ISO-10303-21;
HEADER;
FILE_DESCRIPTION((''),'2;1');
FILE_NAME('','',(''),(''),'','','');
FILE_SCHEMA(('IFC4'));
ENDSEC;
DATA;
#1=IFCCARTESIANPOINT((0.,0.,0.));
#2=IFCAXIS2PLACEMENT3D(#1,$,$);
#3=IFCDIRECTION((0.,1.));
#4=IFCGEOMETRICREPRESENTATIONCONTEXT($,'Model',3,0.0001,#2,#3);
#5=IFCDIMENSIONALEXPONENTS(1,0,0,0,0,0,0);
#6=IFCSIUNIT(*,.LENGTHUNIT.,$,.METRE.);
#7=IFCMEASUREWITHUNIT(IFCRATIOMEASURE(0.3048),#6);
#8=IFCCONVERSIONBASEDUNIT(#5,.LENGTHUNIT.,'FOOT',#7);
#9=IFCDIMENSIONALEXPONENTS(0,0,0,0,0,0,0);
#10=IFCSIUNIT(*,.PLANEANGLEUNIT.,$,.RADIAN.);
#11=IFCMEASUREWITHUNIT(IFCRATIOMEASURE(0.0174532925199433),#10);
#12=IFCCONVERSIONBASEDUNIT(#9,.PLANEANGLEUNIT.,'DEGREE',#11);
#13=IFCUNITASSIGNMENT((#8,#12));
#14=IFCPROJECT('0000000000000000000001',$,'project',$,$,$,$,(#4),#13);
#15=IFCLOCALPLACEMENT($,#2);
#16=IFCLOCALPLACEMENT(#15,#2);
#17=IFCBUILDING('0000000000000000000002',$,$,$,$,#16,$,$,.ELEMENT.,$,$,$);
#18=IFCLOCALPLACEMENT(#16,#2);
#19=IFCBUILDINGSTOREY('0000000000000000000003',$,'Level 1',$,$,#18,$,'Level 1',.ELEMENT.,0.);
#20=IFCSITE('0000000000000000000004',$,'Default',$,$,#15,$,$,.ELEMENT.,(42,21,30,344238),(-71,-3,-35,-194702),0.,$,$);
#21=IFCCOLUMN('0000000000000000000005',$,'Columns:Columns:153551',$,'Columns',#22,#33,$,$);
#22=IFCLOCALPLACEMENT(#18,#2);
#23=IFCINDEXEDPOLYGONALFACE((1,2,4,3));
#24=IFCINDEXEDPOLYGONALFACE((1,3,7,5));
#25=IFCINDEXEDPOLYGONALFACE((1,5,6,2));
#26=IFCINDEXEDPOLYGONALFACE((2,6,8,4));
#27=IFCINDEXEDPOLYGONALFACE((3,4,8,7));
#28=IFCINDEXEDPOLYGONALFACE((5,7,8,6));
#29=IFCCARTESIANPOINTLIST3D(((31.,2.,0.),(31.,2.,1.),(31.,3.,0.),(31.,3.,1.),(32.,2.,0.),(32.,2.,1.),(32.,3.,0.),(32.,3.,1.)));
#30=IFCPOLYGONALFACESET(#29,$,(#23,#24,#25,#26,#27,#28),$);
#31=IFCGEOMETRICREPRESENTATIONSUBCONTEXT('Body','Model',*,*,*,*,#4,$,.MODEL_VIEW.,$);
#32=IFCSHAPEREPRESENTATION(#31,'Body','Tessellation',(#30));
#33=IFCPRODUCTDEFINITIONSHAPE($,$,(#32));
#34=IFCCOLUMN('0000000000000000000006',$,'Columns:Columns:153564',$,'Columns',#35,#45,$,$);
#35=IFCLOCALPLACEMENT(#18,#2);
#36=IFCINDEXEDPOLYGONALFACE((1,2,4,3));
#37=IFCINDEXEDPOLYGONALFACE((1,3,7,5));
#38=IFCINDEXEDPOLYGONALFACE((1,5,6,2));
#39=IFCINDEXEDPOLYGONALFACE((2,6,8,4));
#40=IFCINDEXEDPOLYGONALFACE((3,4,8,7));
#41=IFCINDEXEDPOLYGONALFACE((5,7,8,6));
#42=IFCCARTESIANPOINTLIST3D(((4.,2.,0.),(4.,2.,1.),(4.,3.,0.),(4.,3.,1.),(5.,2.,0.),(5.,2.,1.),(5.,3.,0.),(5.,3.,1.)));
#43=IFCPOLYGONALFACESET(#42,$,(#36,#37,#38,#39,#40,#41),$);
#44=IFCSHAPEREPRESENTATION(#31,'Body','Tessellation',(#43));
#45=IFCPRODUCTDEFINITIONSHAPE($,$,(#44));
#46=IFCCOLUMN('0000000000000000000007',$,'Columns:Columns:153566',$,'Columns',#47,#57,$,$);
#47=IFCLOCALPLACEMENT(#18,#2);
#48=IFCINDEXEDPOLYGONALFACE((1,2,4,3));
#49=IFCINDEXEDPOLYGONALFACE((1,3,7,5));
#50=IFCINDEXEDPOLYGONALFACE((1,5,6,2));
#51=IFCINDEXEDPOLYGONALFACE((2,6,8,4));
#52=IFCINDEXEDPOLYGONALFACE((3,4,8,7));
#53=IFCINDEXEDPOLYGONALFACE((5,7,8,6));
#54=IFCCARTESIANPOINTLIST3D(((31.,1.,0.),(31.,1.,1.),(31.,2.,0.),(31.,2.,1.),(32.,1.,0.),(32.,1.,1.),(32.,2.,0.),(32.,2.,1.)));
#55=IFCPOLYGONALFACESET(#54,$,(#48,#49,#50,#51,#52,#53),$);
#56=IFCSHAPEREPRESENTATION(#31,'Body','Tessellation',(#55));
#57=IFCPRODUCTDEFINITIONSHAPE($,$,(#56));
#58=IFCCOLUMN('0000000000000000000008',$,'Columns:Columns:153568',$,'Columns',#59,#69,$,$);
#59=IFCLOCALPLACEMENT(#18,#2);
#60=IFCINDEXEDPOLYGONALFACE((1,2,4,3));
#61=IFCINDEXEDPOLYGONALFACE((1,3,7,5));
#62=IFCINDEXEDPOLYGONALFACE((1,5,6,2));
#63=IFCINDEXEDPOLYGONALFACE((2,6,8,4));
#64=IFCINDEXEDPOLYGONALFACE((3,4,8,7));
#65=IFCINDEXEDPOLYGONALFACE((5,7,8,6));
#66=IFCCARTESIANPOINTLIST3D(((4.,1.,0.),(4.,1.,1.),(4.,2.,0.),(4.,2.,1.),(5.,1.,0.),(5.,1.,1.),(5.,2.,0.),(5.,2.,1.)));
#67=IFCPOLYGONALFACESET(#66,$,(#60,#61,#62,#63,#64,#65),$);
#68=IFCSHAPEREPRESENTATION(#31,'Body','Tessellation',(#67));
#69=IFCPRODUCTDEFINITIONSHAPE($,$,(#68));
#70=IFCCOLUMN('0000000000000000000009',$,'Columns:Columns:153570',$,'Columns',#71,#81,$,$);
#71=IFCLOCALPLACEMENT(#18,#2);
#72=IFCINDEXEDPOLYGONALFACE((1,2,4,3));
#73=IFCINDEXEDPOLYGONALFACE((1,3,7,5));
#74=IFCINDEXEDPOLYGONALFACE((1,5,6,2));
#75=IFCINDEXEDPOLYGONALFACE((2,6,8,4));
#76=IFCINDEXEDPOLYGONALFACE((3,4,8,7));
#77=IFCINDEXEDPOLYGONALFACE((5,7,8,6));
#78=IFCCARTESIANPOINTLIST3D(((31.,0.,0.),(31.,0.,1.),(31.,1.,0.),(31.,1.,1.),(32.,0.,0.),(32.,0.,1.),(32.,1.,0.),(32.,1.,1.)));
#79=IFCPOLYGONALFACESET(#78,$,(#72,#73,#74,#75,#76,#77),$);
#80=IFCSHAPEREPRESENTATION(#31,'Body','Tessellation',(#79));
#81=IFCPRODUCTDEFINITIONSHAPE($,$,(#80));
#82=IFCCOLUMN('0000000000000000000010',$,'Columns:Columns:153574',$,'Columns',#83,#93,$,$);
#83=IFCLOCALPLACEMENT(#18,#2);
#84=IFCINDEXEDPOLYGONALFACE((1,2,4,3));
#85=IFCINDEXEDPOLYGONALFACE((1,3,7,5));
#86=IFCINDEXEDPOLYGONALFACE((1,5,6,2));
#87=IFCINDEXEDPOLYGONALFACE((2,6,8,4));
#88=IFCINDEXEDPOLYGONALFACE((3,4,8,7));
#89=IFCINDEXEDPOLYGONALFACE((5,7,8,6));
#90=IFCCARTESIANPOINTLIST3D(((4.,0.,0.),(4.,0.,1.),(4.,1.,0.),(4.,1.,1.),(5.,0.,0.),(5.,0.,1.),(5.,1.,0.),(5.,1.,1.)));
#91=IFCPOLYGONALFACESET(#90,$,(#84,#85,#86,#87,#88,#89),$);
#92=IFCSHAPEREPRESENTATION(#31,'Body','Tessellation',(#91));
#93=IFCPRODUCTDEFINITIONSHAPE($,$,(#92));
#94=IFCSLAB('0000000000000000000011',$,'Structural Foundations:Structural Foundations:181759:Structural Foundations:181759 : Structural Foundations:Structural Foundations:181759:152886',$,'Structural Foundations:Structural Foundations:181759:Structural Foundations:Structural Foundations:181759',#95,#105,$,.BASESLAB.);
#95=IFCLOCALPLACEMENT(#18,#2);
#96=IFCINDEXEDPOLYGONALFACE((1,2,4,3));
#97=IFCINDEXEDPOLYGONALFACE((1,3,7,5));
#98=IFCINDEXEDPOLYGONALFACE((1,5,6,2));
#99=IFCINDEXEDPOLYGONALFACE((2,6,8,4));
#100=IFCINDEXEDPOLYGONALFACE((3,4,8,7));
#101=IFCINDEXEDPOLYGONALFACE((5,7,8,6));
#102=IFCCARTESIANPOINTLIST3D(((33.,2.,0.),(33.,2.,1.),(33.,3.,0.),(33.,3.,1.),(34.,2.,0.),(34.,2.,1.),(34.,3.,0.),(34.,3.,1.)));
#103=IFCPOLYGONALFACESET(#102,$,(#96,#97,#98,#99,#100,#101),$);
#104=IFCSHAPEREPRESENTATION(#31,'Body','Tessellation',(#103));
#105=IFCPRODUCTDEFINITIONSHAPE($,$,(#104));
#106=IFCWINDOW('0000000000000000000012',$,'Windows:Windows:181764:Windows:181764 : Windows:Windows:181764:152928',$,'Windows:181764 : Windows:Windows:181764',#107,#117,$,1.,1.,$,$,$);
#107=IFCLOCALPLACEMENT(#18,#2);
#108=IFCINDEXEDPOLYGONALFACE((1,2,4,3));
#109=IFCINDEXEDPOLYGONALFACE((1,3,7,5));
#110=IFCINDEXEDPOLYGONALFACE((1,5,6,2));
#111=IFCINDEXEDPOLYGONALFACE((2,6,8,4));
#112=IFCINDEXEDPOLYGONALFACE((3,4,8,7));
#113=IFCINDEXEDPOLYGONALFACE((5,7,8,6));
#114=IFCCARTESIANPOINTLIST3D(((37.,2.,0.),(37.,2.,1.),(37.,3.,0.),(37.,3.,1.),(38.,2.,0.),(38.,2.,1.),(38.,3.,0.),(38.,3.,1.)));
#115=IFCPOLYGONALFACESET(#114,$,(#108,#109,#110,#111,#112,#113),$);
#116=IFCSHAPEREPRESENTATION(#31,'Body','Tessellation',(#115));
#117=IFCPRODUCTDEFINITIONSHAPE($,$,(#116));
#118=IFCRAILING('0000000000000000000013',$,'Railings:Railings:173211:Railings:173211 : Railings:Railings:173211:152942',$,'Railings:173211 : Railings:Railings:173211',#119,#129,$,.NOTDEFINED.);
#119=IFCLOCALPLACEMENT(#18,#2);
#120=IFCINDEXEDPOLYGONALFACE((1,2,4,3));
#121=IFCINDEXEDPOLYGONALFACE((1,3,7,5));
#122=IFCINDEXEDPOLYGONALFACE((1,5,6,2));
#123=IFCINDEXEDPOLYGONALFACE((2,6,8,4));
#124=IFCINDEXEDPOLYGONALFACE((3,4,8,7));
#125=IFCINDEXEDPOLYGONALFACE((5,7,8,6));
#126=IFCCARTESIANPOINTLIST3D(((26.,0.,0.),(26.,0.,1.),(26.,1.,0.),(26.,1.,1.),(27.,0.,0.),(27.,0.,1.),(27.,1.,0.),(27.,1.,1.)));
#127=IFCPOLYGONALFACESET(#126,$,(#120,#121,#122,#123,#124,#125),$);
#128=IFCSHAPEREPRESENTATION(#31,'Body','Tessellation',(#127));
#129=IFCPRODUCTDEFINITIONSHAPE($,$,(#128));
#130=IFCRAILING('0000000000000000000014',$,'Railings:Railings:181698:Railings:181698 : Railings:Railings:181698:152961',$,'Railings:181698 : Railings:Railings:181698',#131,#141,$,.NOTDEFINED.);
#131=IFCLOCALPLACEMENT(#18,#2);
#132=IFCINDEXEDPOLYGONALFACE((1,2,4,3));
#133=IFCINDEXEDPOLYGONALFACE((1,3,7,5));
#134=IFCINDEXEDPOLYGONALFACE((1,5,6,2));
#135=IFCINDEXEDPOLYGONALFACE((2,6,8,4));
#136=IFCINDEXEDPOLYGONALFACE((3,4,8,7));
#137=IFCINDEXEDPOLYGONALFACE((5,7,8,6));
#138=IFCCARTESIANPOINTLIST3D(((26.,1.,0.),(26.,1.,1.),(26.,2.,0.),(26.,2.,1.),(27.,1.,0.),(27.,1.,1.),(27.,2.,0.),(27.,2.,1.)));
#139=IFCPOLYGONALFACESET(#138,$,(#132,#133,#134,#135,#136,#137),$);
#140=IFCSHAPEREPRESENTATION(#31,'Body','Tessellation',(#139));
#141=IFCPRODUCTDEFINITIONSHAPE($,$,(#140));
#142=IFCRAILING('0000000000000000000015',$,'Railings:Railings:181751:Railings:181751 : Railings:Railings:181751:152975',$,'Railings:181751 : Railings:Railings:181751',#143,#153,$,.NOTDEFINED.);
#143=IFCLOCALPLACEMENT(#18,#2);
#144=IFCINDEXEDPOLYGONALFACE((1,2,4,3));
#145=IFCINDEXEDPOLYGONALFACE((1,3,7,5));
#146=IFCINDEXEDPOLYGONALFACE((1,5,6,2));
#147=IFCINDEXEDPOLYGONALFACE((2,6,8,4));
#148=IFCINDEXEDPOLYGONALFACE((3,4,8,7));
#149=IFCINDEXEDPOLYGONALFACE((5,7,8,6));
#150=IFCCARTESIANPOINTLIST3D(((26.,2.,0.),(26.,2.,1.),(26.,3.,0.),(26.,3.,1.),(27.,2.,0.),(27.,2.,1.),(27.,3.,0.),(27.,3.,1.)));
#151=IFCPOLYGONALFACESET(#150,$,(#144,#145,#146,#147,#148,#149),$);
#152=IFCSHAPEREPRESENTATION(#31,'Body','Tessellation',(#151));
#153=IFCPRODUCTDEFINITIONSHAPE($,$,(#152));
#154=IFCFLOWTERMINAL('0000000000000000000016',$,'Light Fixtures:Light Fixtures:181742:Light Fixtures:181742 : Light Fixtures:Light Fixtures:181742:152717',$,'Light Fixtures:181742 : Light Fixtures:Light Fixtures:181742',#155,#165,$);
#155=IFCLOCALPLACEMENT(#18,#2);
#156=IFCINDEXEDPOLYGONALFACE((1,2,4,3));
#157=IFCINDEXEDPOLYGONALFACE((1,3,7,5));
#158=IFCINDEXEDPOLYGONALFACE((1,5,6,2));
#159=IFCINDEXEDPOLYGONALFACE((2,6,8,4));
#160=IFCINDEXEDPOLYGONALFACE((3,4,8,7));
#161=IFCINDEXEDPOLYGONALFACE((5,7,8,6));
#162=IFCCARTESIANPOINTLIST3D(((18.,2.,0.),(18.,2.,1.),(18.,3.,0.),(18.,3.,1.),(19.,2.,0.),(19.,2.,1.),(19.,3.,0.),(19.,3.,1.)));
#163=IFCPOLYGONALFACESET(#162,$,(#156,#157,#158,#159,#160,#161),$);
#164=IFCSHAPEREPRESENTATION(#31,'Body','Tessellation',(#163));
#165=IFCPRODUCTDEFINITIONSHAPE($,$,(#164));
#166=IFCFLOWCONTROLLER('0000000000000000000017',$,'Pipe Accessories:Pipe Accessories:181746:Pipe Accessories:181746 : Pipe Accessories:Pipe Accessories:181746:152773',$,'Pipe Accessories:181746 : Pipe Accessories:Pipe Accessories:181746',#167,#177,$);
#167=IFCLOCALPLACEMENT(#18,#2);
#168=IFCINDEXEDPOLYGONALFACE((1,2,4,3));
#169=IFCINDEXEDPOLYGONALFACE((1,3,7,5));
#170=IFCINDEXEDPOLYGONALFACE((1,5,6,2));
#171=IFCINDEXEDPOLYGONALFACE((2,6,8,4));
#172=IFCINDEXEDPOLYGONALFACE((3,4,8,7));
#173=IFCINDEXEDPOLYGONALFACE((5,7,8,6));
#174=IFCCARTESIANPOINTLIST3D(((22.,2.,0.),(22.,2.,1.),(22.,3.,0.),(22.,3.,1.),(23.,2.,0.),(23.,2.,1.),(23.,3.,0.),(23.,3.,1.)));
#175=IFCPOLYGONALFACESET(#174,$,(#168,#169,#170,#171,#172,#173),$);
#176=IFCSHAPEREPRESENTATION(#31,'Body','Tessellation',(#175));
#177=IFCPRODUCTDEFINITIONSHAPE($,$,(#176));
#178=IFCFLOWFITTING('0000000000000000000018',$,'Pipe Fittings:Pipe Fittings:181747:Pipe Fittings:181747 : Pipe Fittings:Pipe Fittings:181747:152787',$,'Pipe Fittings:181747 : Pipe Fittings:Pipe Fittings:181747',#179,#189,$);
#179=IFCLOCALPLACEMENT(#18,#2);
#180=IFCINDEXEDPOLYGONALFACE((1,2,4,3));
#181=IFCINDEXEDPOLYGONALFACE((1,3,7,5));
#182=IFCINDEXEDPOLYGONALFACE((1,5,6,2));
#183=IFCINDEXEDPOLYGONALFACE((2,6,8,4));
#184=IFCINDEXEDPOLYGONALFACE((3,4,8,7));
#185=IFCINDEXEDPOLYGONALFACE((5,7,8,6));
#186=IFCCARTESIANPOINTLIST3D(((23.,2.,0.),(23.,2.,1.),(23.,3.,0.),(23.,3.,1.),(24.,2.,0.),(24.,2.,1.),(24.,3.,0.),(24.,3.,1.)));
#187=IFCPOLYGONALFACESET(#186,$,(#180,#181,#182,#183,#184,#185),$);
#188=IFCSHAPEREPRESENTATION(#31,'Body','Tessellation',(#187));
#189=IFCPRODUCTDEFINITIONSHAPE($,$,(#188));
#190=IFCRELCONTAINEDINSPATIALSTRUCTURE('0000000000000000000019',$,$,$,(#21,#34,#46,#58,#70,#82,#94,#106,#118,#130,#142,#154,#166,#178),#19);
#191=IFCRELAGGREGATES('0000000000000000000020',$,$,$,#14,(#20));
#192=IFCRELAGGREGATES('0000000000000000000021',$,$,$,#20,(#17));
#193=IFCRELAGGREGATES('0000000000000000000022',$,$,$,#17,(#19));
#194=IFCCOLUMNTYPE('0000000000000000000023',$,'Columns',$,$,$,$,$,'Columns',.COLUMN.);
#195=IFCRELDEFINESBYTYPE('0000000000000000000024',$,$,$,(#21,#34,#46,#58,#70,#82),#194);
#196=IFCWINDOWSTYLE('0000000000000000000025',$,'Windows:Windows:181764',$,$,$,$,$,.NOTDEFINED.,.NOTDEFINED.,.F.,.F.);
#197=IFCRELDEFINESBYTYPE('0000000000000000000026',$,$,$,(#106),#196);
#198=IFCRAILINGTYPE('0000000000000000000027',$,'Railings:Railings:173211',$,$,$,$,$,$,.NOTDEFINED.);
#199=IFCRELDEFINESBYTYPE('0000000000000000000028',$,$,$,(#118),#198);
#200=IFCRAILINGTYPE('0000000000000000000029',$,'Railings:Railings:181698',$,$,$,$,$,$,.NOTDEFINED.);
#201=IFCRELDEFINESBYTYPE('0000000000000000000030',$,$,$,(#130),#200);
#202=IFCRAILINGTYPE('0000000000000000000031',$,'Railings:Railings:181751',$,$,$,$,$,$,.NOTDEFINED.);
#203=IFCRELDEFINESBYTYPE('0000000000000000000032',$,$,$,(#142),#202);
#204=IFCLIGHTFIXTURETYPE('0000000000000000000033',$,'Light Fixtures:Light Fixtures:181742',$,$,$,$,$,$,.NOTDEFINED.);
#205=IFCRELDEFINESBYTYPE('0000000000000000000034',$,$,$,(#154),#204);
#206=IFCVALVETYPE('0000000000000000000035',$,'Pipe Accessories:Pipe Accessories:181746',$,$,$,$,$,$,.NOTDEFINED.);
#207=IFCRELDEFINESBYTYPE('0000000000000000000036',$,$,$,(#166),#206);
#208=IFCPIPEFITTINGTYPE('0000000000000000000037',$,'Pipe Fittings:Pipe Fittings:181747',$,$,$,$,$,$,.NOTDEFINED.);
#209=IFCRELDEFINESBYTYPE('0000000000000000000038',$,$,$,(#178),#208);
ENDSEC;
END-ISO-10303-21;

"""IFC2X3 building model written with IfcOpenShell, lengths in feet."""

from ifc_helpers import new_model, entity, si_unit, converted_unit, direction, frame, frame_2d, origin, origin_2d_with_axis, place, context, subcontext, project, spatial, rectangle, extrude, source, transform, mapped, type_object, type_shapes, element, save


model = new_model("IFC2X3")

# Units and contexts
model_context = context("Model", 3, precision=0.0001, world=origin(), true_north=direction((0.0, 1.0)))
body_context = subcontext(model_context, "Body", "Model", "MODEL_VIEW")
ifc_project = project(units=[converted_unit("LENGTHUNIT", "FOOT", entity("IfcRatioMeasure", 0.3048), si_unit("LENGTHUNIT", "METRE"), dimensions=[1, 0, 0, 0, 0, 0, 0]), converted_unit("PLANEANGLEUNIT", "DEGREE", entity("IfcRatioMeasure", 0.0174532925199433), si_unit("PLANEANGLEUNIT", "RADIAN"), dimensions=[0, 0, 0, 0, 0, 0, 0])], contexts=[model_context])

# Site, building, storey
site_placement = place(None, origin())
site = spatial("IfcSite", under=ifc_project, at=site_placement, Name="Default", CompositionType="ELEMENT", RefLatitude=(42, 21, 30, 344238), RefLongitude=(-71, -3, -35, -194702), RefElevation=0.0)
building_placement = place(site_placement, origin())
building = spatial("IfcBuilding", under=site, at=building_placement, CompositionType="ELEMENT")
storey_placement = place(building_placement, origin())
storey = spatial("IfcBuildingStorey", under=building, at=storey_placement, Name="Level 1", LongName="Level 1", CompositionType="ELEMENT", Elevation=0.0)

# Columns
column_type = type_object("IfcColumnType", Name="Columns", ElementType="Columns", PredefinedType="COLUMN")
shared_shape_1 = source(origin(), body_context, "Body", "SweptSolid", [
    extrude(rectangle(XDim=1.0, YDim=1.0, at=frame_2d((0.0, 0.0), x_axis=(1.0, 0.0))), frame((0.5, 0.5, 0.0), z_axis=(0.0, 0.0, 1.0), x_axis=(0.0, -1.0, 0.0)), (0.0, 0.0, 1.0), 1.0),
])
type_shapes(column_type, [shared_shape_1])
for number, where, name in (
    (1, (31.0, 2.0, 0.0), "Columns:Columns:153551"),
    (2, (4.0, 2.0, 0.0), "Columns:Columns:153564"),
    (3, (31.0, 1.0, 0.0), "Columns:Columns:153566"),
    (4, (4.0, 1.0, 0.0), "Columns:Columns:153568"),
    (5, (31.0, 0.0, 0.0), "Columns:Columns:153570"),
    (6, (4.0, 0.0, 0.0), "Columns:Columns:153574"),
):
    element("IfcColumn", number, at=place(storey_placement, frame(where)), inside=storey, type_object=column_type, Name=name, ObjectType="Columns", context=body_context, shape_type="MappedRepresentation", body=[
        mapped(shared_shape_1, transform((0.0, 0.0, 0.0), scale=1.0)),
    ])

# Slab
slab_placement = place(storey_placement, origin())
element("IfcSlab", 7, at=slab_placement, inside=storey, Name="Structural Foundations:Structural Foundations:181759:Structural Foundations:181759 : Structural Foundations:Structural Foundations:181759:152886", ObjectType="Structural Foundations:Structural Foundations:181759:Structural Foundations:Structural Foundations:181759", PredefinedType="BASESLAB", context=body_context, shape_type="SweptSolid", body=[
    extrude(rectangle(XDim=1.0, YDim=1.0, at=frame_2d((0.0, 0.0), x_axis=(1.0, 0.0))), frame((33.5, 2.5, 0.0), z_axis=(0.0, 0.0, 1.0), x_axis=(-1.0, 0.0, 0.0)), (0.0, 0.0, 1.0), 1.0),
])

# Window
window_style = type_object("IfcWindowStyle", Name="Windows:Windows:181764", ConstructionType="NOTDEFINED", OperationType="NOTDEFINED", ParameterTakesPrecedence=False, Sizeable=False)
shared_shape_2 = source(origin(), body_context, "Body", "SweptSolid", [
    extrude(rectangle(XDim=1.0, YDim=1.0, at=frame_2d((0.0, 0.0), x_axis=(1.0, 0.0))), frame((37.5, 2.5, 0.0), z_axis=(0.0, 0.0, 1.0), x_axis=(-1.0, 0.0, 0.0)), (0.0, 0.0, 1.0), 1.0),
])
type_shapes(window_style, [shared_shape_2])
window_placement = place(storey_placement, origin())
element("IfcWindow", 8, at=window_placement, inside=storey, type_object=window_style, Name="Windows:Windows:181764:Windows:181764 : Windows:Windows:181764:152928", ObjectType="Windows:181764 : Windows:Windows:181764", OverallHeight=1.0, OverallWidth=1.0, context=body_context, shape_type="MappedRepresentation", body=[
    mapped(shared_shape_2, transform((0.0, 0.0, 0.0), scale=1.0)),
])

# Railings
railing_type_1 = type_object("IfcRailingType", Name="Railings:Railings:173211", PredefinedType="NOTDEFINED")
shared_shape_3 = source(origin(), body_context, "Body", "SweptSolid", [
    extrude(rectangle(XDim=1.0, YDim=1.0, at=origin_2d_with_axis()), frame((26.5, 0.5, 0.0), z_axis=(0.0, 0.0, 1.0), x_axis=(-1.0, 0.0, 0.0)), (0.0, 0.0, 1.0), 1.0),
])
type_shapes(railing_type_1, [shared_shape_3])
railing_1_placement = place(storey_placement, origin())
element("IfcRailing", 9, at=railing_1_placement, inside=storey, type_object=railing_type_1, Name="Railings:Railings:173211:Railings:173211 : Railings:Railings:173211:152942", ObjectType="Railings:173211 : Railings:Railings:173211", PredefinedType="NOTDEFINED", context=body_context, shape_type="MappedRepresentation", body=[
    mapped(shared_shape_3, transform((0.0, 0.0, 0.0), scale=1.0)),
])
railing_type_2 = type_object("IfcRailingType", Name="Railings:Railings:181698", PredefinedType="NOTDEFINED")
shared_shape_4 = source(origin(), body_context, "Body", "SweptSolid", [
    extrude(rectangle(XDim=1.0, YDim=1.0, at=frame_2d((0.0, 0.0), x_axis=(1.0, 0.0))), frame((26.5, 1.5, 0.0), z_axis=(0.0, 0.0, 1.0), x_axis=(-1.0, 0.0, 0.0)), (0.0, 0.0, 1.0), 1.0),
])
type_shapes(railing_type_2, [shared_shape_4])
railing_2_placement = place(storey_placement, origin())
element("IfcRailing", 10, at=railing_2_placement, inside=storey, type_object=railing_type_2, Name="Railings:Railings:181698:Railings:181698 : Railings:Railings:181698:152961", ObjectType="Railings:181698 : Railings:Railings:181698", PredefinedType="NOTDEFINED", context=body_context, shape_type="MappedRepresentation", body=[
    mapped(shared_shape_4, transform((0.0, 0.0, 0.0), scale=1.0)),
])
railing_type_3 = type_object("IfcRailingType", Name="Railings:Railings:181751", PredefinedType="NOTDEFINED")
shared_shape_5 = source(origin(), body_context, "Body", "SweptSolid", [
    extrude(rectangle(XDim=1.0, YDim=1.0, at=frame_2d((0.0, 0.0), x_axis=(1.0, 0.0))), frame((26.5, 2.5, 0.0), z_axis=(0.0, 0.0, 1.0), x_axis=(-1.0, 0.0, 0.0)), (0.0, 0.0, 1.0), 1.0),
])
type_shapes(railing_type_3, [shared_shape_5])
railing_3_placement = place(storey_placement, origin())
element("IfcRailing", 11, at=railing_3_placement, inside=storey, type_object=railing_type_3, Name="Railings:Railings:181751:Railings:181751 : Railings:Railings:181751:152975", ObjectType="Railings:181751 : Railings:Railings:181751", PredefinedType="NOTDEFINED", context=body_context, shape_type="MappedRepresentation", body=[
    mapped(shared_shape_5, transform((0.0, 0.0, 0.0), scale=1.0)),
])

# Flow terminal
light_fixture_type = type_object("IfcLightFixtureType", Name="Light Fixtures:Light Fixtures:181742", PredefinedType="NOTDEFINED")
shared_shape_6 = source(origin(), body_context, "Body", "SweptSolid", [
    extrude(rectangle(XDim=1.0, YDim=1.0, at=frame_2d((0.0, 0.0), x_axis=(1.0, 0.0))), frame((18.5, 2.5, 0.0), z_axis=(0.0, 0.0, 1.0), x_axis=(-1.0, 0.0, 0.0)), (0.0, 0.0, 1.0), 1.0),
])
type_shapes(light_fixture_type, [shared_shape_6])
flow_terminal_placement = place(storey_placement, origin())
element("IfcFlowTerminal", 12, at=flow_terminal_placement, inside=storey, type_object=light_fixture_type, Name="Light Fixtures:Light Fixtures:181742:Light Fixtures:181742 : Light Fixtures:Light Fixtures:181742:152717", ObjectType="Light Fixtures:181742 : Light Fixtures:Light Fixtures:181742", context=body_context, shape_type="MappedRepresentation", body=[
    mapped(shared_shape_6, transform((0.0, 0.0, 0.0), scale=1.0)),
])

# Flow controller
valve_type = type_object("IfcValveType", Name="Pipe Accessories:Pipe Accessories:181746", PredefinedType="NOTDEFINED")
shared_shape_7 = source(origin(), body_context, "Body", "SweptSolid", [
    extrude(rectangle(XDim=1.0, YDim=1.0, at=frame_2d((0.0, 0.0), x_axis=(1.0, 0.0))), frame((22.5, 2.5, 0.0), z_axis=(0.0, 0.0, 1.0), x_axis=(-1.0, 0.0, 0.0)), (0.0, 0.0, 1.0), 1.0),
])
type_shapes(valve_type, [shared_shape_7])
flow_controller_placement = place(storey_placement, origin())
element("IfcFlowController", 13, at=flow_controller_placement, inside=storey, type_object=valve_type, Name="Pipe Accessories:Pipe Accessories:181746:Pipe Accessories:181746 : Pipe Accessories:Pipe Accessories:181746:152773", ObjectType="Pipe Accessories:181746 : Pipe Accessories:Pipe Accessories:181746", context=body_context, shape_type="MappedRepresentation", body=[
    mapped(shared_shape_7, transform((0.0, 0.0, 0.0), scale=1.0)),
])

# Flow fitting
pipe_fitting_type = type_object("IfcPipeFittingType", Name="Pipe Fittings:Pipe Fittings:181747", PredefinedType="NOTDEFINED")
shared_shape_8 = source(origin(), body_context, "Body", "SweptSolid", [
    extrude(rectangle(XDim=1.0, YDim=1.0, at=frame_2d((0.0, 0.0), x_axis=(1.0, 0.0))), frame((23.5, 2.5, 0.0), z_axis=(0.0, 0.0, 1.0), x_axis=(-1.0, 0.0, 0.0)), (0.0, 0.0, 1.0), 1.0),
])
type_shapes(pipe_fitting_type, [shared_shape_8])
flow_fitting_placement = place(storey_placement, origin())
element("IfcFlowFitting", 14, at=flow_fitting_placement, inside=storey, type_object=pipe_fitting_type, Name="Pipe Fittings:Pipe Fittings:181747:Pipe Fittings:181747 : Pipe Fittings:Pipe Fittings:181747:152787", ObjectType="Pipe Fittings:181747 : Pipe Fittings:Pipe Fittings:181747", context=body_context, shape_type="MappedRepresentation", body=[
    mapped(shared_shape_8, transform((0.0, 0.0, 0.0), scale=1.0)),
])

save(model, "model.ifc")
